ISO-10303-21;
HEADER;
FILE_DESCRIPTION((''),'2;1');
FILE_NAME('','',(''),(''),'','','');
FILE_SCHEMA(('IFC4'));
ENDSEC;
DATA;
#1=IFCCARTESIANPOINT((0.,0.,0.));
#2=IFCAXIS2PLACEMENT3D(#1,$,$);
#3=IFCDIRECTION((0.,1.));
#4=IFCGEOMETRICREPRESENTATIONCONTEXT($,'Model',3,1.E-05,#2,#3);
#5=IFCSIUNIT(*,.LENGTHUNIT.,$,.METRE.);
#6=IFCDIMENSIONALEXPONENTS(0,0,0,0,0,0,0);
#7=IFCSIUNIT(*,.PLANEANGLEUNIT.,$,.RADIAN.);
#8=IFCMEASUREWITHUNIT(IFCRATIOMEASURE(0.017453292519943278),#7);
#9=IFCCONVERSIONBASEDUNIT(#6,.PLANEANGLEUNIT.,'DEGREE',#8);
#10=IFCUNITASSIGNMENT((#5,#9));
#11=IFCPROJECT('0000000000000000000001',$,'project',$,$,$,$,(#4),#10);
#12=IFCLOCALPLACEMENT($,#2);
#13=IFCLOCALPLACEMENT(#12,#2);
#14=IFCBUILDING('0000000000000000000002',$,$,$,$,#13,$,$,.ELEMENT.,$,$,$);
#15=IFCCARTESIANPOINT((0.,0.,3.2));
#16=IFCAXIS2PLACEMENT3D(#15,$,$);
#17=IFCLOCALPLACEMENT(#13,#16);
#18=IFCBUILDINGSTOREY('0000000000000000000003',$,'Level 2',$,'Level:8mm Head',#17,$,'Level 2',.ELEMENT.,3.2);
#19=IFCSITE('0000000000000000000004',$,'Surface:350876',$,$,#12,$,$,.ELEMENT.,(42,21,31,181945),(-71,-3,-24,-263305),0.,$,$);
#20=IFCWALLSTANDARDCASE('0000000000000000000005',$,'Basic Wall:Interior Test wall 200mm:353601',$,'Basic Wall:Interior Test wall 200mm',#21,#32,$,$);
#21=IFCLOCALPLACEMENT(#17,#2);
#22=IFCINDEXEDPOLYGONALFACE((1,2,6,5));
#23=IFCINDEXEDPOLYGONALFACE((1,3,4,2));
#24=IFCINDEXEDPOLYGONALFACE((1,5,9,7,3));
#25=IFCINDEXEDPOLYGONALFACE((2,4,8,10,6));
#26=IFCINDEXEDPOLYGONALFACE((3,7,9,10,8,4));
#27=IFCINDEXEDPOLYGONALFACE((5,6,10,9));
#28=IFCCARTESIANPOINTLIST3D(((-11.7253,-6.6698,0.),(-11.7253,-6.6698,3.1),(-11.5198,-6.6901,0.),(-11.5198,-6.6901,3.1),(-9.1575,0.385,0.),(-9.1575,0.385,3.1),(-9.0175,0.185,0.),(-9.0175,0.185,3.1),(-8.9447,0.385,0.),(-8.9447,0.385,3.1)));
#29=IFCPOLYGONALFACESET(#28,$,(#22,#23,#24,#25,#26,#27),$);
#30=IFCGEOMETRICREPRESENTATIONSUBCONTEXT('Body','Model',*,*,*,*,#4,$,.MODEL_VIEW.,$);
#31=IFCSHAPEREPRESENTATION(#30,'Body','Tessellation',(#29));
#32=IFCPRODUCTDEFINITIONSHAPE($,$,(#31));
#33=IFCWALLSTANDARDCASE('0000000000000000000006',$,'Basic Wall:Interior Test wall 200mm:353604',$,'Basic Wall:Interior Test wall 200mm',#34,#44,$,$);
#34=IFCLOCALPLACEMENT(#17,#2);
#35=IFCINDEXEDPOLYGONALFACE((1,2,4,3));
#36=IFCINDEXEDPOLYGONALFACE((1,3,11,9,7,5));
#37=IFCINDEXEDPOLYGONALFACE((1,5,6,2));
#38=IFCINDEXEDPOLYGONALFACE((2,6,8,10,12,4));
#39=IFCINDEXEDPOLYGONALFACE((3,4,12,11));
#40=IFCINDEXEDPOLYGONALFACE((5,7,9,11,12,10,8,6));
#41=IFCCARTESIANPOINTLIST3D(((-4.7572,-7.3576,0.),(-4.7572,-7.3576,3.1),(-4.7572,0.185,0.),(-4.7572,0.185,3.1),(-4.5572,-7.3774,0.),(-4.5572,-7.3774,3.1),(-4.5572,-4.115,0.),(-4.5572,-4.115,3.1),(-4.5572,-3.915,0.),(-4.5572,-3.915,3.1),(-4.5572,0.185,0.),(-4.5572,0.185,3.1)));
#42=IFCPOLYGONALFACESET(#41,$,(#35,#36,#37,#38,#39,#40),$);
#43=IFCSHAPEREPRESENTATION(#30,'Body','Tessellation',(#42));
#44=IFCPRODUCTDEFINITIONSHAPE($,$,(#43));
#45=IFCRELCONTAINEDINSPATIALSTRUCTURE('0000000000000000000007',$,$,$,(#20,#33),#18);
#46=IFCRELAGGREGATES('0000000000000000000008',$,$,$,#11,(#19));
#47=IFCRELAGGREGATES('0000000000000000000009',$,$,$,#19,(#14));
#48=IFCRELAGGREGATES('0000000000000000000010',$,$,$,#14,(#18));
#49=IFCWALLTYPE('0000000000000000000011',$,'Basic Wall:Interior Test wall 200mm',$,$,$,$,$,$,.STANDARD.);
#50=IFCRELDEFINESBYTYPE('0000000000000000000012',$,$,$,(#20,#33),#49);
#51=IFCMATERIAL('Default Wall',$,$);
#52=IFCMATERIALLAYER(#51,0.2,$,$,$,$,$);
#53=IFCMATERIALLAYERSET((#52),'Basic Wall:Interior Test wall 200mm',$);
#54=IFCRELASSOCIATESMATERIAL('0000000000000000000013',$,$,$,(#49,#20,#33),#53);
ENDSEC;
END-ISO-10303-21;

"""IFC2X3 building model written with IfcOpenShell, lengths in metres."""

from ifc_helpers import new_model, entity, si_unit, converted_unit, direction, frame, origin, place, context, subcontext, project, spatial, polyline, outline, extrude, material, layer, layer_set, layer_usage, type_object, element, save


model = new_model("IFC2X3")

# Units and contexts
model_context = context("Model", 3, precision=1e-05, world=origin(), true_north=direction((0.0, 1.0)))
body_context = subcontext(model_context, "Body", "Model", "MODEL_VIEW")
ifc_project = project(units=[si_unit("LENGTHUNIT", "METRE"), converted_unit("PLANEANGLEUNIT", "DEGREE", entity("IfcRatioMeasure", 0.017453292519943278), si_unit("PLANEANGLEUNIT", "RADIAN"), dimensions=[0, 0, 0, 0, 0, 0, 0])], contexts=[model_context])

# Site, building, storey
site_placement = place(None, origin())
site = spatial("IfcSite", under=ifc_project, at=site_placement, Name="Surface:350876", CompositionType="ELEMENT", RefLatitude=(42, 21, 31, 181945), RefLongitude=(-71, -3, -24, -263305), RefElevation=0.0)
building_placement = place(site_placement, origin())
building = spatial("IfcBuilding", under=site, at=building_placement, CompositionType="ELEMENT")
storey_placement = place(building_placement, frame((0.0, 0.0, 3.2)))
storey = spatial("IfcBuildingStorey", under=building, at=storey_placement, Name="Level 2", ObjectType="Level:8mm Head", LongName="Level 2", CompositionType="ELEMENT", Elevation=3.2)

# Shared definitions
ifc_material_1 = material(Name="Default Wall")

# Walls
ifc_layer_1 = layer(ifc_material_1, 0.2)
ifc_layer_set_1 = layer_set([ifc_layer_1], Name="Basic Wall:Interior Test wall 200mm")
ifc_layer_usage_1 = layer_usage(ifc_layer_set_1, "AXIS2", "NEGATIVE", 0.1)
wall_type_1 = type_object("IfcWallType", Name="Basic Wall:Interior Test wall 200mm", PredefinedType="STANDARD", material=ifc_layer_set_1)
wall_1_placement = place(storey_placement, frame((-11.6313, -6.704, 0.0), z_axis=(0.0, 0.0, 1.0), x_axis=(0.34202, 0.939693, 0.0)))
element("IfcWallStandardCase", 1, at=wall_1_placement, inside=storey, type_object=wall_type_1, material=ifc_layer_usage_1, Name="Basic Wall:Interior Test wall 200mm:353601", ObjectType="Basic Wall:Interior Test wall 200mm", context=body_context, shape_type="SweptSolid", body=[
    extrude(outline(polyline([(7.5803, -0.1), (7.5076, 0.1), (0.0, 0.1), (0.0512, -0.1), (7.3675, -0.1), (7.5803, -0.1)])), origin(), (0.0, 0.0, 1.0), 3.1),
])
ifc_layer_usage_2 = layer_usage(ifc_layer_set_1, "AXIS2", "NEGATIVE", 0.1)
wall_2_placement = place(storey_placement, frame((-4.6572, 0.185, 0.0), z_axis=(0.0, 0.0, 1.0), x_axis=(0.0, -1.0, 0.0)))
element("IfcWallStandardCase", 2, at=wall_2_placement, inside=storey, type_object=wall_type_1, material=ifc_layer_usage_2, Name="Basic Wall:Interior Test wall 200mm:353604", ObjectType="Basic Wall:Interior Test wall 200mm", context=body_context, shape_type="SweptSolid", body=[
    extrude(outline(polyline([(7.5426, -0.1), (7.5624, 0.1), (4.3, 0.1), (4.1, 0.1), (0.0, 0.1), (0.0, -0.1), (7.5426, -0.1)])), origin(), (0.0, 0.0, 1.0), 3.1),
])

save(model, "model.ifc")
